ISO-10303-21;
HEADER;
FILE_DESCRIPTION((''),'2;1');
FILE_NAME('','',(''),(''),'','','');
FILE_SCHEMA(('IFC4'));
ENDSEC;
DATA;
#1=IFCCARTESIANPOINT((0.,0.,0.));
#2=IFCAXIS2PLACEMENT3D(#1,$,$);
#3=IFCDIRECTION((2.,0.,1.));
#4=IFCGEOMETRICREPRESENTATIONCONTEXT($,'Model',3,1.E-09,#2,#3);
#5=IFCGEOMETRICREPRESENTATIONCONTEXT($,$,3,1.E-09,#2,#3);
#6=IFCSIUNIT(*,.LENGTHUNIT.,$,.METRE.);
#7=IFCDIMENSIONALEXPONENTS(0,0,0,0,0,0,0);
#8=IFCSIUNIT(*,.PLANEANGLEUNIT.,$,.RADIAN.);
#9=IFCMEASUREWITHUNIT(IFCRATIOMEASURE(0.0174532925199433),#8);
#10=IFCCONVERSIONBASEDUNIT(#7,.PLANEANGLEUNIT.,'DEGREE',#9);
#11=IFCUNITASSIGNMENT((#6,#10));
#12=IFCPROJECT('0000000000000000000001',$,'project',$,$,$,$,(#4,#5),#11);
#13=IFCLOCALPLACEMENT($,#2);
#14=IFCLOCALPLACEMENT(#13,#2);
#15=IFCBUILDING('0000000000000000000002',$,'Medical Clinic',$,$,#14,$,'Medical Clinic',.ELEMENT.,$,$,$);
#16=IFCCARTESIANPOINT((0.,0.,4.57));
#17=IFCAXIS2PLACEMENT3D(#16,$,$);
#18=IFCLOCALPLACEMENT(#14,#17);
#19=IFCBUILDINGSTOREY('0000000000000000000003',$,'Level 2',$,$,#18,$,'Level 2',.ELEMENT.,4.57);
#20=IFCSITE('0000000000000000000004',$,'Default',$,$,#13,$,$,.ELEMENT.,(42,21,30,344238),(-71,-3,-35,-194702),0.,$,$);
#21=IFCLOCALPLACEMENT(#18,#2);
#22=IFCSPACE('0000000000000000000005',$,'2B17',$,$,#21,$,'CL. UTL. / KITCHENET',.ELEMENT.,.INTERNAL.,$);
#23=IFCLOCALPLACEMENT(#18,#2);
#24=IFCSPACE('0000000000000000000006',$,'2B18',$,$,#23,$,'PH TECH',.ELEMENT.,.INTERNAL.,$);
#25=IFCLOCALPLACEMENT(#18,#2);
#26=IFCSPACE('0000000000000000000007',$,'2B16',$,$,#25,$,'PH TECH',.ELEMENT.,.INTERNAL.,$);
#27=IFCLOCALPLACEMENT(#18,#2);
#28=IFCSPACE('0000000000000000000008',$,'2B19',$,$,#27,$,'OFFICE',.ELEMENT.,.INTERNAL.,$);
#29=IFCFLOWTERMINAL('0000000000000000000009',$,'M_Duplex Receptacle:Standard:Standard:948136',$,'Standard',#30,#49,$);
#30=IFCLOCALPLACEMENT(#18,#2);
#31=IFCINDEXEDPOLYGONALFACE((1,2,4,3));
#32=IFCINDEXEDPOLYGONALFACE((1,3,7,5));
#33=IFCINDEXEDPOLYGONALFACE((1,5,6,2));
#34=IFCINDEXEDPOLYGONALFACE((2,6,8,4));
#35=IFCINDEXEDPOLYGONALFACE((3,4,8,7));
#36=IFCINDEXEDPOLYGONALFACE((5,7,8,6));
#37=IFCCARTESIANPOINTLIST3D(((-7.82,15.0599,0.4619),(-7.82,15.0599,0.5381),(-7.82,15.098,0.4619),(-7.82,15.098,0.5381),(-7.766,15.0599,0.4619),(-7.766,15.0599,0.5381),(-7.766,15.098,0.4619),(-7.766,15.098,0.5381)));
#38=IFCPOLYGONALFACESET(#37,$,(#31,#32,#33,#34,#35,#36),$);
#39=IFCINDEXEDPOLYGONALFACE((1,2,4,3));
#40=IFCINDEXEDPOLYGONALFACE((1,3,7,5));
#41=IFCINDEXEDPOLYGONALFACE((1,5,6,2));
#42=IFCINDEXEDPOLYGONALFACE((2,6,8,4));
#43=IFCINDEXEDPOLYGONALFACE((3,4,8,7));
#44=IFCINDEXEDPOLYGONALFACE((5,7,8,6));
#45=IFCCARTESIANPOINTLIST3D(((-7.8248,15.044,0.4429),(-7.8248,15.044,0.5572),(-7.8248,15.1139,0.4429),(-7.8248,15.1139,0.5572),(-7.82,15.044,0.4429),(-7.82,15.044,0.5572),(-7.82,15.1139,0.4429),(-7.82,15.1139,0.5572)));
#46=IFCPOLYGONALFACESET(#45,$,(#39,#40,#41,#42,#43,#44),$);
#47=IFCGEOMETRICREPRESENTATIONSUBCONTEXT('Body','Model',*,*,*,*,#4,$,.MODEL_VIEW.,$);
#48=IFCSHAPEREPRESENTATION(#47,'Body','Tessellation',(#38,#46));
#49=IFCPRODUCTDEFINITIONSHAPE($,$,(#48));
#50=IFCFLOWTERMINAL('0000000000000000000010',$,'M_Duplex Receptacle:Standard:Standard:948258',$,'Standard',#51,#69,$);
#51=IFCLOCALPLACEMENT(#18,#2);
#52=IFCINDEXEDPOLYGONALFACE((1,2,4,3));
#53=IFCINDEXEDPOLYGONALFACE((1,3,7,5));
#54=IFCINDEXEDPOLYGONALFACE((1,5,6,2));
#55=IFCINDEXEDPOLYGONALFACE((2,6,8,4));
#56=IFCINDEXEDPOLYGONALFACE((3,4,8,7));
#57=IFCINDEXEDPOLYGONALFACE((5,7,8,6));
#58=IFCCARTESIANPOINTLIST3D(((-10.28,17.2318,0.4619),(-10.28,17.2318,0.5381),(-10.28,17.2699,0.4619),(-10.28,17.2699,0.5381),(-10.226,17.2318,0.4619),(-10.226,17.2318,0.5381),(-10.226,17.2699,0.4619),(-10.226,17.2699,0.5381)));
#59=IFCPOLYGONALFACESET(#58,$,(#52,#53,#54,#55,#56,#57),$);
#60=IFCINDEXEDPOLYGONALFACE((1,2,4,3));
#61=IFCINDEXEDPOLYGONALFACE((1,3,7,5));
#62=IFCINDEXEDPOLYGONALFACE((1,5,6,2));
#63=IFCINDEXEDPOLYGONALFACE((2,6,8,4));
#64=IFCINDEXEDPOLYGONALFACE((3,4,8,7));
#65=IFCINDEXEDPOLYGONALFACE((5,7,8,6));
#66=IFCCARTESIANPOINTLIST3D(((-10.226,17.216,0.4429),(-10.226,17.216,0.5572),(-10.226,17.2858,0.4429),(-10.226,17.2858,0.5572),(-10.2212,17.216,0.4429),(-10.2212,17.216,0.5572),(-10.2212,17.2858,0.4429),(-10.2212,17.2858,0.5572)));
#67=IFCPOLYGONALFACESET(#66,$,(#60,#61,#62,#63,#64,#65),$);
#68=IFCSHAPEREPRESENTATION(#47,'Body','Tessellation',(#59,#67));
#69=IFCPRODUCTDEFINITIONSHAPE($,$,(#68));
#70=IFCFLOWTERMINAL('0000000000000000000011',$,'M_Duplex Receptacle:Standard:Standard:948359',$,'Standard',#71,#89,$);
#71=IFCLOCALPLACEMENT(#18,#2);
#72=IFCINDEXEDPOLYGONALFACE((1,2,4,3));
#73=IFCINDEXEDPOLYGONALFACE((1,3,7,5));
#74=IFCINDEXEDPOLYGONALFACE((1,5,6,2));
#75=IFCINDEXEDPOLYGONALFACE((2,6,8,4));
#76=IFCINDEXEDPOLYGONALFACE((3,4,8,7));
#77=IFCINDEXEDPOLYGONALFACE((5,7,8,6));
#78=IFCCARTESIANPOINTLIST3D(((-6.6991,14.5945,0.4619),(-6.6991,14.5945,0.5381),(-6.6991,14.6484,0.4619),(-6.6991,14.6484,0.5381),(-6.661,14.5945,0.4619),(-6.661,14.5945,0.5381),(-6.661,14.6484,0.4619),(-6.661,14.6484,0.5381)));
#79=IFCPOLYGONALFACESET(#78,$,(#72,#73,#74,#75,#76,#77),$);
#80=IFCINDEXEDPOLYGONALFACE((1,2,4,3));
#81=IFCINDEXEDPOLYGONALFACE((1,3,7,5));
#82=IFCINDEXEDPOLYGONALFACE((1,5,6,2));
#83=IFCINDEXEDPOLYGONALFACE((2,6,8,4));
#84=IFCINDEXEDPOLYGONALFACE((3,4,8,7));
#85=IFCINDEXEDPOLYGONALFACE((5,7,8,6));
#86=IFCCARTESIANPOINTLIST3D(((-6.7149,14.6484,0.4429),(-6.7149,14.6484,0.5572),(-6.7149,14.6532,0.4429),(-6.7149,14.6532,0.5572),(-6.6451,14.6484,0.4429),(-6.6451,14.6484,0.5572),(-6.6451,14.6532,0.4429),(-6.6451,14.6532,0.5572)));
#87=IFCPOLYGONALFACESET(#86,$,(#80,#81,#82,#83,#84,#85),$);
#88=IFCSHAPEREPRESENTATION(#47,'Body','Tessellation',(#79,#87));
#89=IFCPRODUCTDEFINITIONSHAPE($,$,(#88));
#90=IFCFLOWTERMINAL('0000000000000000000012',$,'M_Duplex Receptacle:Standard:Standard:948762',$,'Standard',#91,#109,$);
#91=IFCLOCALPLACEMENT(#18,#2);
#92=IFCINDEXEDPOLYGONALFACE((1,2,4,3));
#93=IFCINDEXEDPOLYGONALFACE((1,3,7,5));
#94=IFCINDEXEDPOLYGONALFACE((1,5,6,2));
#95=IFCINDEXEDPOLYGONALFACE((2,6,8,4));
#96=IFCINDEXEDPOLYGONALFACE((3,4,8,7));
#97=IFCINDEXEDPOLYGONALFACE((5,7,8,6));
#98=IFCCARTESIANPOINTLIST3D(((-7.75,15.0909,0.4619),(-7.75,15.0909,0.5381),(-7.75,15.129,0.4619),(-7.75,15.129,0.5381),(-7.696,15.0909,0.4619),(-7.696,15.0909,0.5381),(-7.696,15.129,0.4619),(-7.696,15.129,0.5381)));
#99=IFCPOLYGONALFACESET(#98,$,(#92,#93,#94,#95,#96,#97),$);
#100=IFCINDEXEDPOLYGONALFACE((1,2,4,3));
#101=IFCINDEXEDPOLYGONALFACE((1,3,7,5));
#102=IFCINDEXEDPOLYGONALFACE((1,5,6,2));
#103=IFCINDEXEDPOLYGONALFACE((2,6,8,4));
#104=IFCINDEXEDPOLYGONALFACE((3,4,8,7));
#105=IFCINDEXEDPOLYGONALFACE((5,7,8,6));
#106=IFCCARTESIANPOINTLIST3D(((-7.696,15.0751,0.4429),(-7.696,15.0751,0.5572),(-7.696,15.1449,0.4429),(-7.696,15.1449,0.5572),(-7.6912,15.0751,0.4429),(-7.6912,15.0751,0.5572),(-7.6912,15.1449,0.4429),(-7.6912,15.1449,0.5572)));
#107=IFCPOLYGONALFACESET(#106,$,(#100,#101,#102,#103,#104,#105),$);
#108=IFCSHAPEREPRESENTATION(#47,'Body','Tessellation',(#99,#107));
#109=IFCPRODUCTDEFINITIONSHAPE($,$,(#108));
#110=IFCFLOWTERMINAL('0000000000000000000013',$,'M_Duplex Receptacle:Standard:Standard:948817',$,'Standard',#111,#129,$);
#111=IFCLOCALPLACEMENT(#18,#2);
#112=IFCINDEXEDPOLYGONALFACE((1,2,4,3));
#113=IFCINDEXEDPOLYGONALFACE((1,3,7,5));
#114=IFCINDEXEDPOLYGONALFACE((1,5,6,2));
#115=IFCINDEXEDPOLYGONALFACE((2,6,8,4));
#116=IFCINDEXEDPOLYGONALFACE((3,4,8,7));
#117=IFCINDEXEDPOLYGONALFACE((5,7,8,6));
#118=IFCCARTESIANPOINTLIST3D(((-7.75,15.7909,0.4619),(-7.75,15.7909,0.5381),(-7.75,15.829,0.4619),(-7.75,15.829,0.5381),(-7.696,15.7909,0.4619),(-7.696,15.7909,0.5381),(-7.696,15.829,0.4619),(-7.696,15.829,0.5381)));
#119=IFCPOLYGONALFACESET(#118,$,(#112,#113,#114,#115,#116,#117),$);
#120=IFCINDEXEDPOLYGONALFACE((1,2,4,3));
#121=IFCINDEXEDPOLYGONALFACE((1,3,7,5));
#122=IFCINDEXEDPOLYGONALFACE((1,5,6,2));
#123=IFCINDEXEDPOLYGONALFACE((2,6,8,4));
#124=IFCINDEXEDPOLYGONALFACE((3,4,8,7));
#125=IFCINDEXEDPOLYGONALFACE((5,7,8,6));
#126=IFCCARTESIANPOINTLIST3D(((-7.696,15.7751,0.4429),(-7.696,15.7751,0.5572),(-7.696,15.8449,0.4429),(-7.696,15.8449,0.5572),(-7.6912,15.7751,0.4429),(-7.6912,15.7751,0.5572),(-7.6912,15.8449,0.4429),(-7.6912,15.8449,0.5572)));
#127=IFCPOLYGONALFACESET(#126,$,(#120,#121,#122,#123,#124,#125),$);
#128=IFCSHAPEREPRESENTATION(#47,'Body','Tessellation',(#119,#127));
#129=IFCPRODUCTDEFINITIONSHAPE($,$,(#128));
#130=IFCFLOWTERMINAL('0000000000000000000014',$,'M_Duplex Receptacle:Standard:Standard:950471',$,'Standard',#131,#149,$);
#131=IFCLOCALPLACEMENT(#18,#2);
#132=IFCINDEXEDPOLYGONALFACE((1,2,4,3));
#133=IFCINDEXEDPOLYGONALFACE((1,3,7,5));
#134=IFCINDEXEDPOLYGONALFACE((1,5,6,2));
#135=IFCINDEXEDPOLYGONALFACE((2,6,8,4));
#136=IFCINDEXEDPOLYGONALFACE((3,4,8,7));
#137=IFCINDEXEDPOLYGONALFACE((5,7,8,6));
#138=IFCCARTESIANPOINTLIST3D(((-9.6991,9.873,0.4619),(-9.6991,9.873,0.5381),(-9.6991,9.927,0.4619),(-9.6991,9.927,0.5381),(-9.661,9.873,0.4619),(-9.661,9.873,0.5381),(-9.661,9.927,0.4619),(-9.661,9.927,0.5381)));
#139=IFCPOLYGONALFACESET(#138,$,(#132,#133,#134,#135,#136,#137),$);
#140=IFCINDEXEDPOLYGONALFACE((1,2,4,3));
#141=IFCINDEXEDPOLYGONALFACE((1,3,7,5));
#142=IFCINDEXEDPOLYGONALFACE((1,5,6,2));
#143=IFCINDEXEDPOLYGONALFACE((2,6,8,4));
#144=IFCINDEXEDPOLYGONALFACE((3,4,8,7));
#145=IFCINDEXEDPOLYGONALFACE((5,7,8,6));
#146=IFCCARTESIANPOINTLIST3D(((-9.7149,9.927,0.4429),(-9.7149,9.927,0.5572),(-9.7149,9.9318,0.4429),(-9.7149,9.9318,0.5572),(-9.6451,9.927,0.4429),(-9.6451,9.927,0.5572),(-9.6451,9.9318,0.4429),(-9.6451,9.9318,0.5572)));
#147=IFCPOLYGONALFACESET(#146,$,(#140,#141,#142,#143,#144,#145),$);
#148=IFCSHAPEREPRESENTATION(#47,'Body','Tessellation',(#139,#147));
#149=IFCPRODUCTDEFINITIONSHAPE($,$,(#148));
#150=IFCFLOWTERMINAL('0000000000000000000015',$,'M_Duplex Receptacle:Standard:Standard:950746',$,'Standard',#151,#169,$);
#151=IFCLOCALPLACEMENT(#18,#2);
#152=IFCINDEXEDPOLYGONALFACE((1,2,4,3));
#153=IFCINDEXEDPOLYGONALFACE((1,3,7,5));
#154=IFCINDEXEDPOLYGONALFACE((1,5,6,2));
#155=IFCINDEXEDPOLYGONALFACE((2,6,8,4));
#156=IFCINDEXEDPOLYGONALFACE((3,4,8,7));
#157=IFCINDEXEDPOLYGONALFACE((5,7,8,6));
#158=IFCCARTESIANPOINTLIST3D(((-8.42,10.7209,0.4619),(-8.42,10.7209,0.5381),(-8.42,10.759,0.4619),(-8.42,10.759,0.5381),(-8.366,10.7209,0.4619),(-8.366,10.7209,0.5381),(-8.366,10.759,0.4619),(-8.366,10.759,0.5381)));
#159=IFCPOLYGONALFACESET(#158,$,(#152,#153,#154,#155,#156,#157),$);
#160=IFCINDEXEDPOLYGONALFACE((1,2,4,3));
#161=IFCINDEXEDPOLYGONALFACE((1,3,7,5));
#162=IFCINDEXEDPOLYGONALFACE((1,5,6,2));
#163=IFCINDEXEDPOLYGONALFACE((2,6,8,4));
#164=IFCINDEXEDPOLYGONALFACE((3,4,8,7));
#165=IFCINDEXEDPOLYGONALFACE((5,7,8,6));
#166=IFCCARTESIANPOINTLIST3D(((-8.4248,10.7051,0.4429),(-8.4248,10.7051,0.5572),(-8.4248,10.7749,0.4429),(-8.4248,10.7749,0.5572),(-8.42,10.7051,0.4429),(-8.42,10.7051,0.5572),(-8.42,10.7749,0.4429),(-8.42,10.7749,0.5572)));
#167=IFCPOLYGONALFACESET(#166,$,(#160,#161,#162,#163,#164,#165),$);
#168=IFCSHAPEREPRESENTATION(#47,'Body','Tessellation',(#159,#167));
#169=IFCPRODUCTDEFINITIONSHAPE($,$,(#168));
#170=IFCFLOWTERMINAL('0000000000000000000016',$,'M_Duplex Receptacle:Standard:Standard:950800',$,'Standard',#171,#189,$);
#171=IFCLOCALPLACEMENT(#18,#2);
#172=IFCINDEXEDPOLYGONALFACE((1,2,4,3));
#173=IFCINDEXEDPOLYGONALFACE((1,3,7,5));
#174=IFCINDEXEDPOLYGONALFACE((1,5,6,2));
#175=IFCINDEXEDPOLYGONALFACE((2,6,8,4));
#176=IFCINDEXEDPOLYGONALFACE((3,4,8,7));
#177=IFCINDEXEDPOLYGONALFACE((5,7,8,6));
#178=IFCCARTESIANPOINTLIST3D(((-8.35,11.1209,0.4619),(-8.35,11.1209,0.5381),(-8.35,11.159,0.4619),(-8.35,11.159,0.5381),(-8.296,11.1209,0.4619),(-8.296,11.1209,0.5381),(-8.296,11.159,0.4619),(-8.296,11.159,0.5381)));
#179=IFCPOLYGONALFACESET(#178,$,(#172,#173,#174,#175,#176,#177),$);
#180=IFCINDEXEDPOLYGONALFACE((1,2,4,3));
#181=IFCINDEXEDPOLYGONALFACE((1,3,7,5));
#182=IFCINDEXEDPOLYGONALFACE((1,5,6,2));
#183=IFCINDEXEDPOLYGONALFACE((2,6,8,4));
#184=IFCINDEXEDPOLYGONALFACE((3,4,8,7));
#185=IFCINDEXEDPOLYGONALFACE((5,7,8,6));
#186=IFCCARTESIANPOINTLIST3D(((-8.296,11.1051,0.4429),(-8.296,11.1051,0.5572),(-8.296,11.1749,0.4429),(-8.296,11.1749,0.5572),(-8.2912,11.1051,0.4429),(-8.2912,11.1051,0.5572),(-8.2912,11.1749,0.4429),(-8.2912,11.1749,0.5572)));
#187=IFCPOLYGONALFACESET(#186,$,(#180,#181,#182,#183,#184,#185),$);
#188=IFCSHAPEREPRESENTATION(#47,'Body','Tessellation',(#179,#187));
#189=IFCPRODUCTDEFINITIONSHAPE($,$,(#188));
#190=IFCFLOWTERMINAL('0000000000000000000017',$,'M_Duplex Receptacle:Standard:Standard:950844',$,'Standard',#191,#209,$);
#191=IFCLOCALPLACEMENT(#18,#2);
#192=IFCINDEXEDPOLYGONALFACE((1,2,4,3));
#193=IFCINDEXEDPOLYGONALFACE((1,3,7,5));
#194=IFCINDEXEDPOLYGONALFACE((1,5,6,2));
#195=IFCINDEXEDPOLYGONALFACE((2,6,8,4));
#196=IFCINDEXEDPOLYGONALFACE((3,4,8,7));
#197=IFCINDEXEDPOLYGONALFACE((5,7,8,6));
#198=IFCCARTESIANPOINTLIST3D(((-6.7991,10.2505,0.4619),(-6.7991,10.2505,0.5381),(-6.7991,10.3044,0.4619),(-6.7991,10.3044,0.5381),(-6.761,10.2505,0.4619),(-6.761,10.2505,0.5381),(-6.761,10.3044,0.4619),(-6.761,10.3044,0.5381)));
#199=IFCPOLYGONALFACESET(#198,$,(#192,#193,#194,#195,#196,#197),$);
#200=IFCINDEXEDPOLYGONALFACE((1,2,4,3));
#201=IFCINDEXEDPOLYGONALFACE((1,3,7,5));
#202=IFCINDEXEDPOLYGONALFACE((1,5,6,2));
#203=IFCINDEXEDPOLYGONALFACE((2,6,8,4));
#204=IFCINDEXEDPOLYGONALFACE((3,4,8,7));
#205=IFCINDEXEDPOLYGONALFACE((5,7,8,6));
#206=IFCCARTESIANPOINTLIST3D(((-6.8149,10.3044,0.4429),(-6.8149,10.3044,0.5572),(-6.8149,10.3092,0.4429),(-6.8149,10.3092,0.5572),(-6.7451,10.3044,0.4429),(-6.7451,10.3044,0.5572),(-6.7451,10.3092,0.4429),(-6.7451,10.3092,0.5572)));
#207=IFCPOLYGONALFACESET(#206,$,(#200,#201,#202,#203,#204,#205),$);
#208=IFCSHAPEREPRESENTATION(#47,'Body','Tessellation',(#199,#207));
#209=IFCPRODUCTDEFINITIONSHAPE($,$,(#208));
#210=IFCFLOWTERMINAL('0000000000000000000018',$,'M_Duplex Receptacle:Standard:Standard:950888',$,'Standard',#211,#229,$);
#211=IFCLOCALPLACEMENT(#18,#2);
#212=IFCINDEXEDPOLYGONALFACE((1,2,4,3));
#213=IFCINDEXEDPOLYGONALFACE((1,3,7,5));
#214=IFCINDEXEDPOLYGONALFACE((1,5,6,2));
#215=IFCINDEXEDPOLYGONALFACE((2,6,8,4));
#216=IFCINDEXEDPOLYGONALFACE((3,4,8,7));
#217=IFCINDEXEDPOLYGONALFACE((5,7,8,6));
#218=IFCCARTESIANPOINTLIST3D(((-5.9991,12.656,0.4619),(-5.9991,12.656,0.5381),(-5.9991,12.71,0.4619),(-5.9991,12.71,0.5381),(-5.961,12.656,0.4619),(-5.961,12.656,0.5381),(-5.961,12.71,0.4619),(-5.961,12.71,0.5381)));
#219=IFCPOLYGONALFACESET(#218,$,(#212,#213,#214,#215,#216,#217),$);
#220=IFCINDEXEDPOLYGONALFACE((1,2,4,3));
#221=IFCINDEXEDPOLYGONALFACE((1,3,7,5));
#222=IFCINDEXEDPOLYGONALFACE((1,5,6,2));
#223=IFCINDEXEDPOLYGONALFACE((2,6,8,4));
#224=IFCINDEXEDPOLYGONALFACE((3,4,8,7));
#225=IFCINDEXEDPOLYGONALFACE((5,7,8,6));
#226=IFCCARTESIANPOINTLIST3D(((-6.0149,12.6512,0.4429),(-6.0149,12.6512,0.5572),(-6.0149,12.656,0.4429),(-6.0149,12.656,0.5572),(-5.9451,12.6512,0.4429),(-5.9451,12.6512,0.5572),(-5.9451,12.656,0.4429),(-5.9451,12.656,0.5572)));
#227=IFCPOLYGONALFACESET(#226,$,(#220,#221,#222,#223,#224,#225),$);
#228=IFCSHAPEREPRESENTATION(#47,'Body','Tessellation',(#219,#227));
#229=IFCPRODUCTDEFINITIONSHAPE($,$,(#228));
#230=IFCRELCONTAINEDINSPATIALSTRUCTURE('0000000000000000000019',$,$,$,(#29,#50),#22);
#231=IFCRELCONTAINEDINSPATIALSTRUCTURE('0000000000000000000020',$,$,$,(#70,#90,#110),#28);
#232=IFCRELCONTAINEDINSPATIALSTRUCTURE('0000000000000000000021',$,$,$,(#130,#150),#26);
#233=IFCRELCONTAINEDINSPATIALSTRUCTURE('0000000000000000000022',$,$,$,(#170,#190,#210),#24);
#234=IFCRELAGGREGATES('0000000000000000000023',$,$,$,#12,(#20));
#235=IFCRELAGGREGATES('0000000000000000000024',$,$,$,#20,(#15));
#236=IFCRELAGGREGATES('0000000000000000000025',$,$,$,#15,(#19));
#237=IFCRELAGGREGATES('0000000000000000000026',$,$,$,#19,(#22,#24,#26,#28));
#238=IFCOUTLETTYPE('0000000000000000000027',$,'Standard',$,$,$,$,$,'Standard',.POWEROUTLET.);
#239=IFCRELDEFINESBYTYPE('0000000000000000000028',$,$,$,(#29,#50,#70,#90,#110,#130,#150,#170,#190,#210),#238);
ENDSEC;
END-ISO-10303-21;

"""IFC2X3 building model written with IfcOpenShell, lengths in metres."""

from ifc_helpers import new_model, entity, si_unit, converted_unit, direction, frame, frame_2d, origin, origin_2d_with_axis, place, context, subcontext, project, spatial, rectangle, extrude, source, transform, mapped, type_object, type_shapes, element, save


model = new_model("IFC2X3")

# Units and contexts
model_context = context("Model", 3, precision=1e-09, world=origin(), true_north=direction((2.0, 0.0, 1.0)))
context_of_model = context(None, 3, precision=1e-09, world=origin(), true_north=direction((2.0, 0.0, 1.0)))
body_context = subcontext(model_context, "Body", "Model", "MODEL_VIEW")
ifc_project = project(units=[si_unit("LENGTHUNIT", "METRE"), converted_unit("PLANEANGLEUNIT", "DEGREE", entity("IfcRatioMeasure", 0.0174532925199433), si_unit("PLANEANGLEUNIT", "RADIAN"), dimensions=[0, 0, 0, 0, 0, 0, 0])], contexts=[model_context, context_of_model])

# Site, building, storey
site_placement = place(None, origin())
site = spatial("IfcSite", under=ifc_project, at=site_placement, Name="Default", CompositionType="ELEMENT", RefLatitude=(42, 21, 30, 344238), RefLongitude=(-71, -3, -35, -194702), RefElevation=0.0)
building_placement = place(site_placement, origin())
building = spatial("IfcBuilding", under=site, at=building_placement, Name="Medical Clinic", LongName="Medical Clinic", CompositionType="ELEMENT")
storey_placement = place(building_placement, frame((0.0, 0.0, 4.57)))
storey = spatial("IfcBuildingStorey", under=building, at=storey_placement, Name="Level 2", LongName="Level 2", CompositionType="ELEMENT", Elevation=4.57)

# Shared definitions
space_1_placement = place(storey_placement, origin())
space_1 = spatial("IfcSpace", under=storey, at=space_1_placement, Name="2B17", LongName="CL. UTL. / KITCHENET", CompositionType="ELEMENT", InteriorOrExteriorSpace="INTERNAL")

# Shared definitions
space_2_placement = place(storey_placement, origin())
space_2 = spatial("IfcSpace", under=storey, at=space_2_placement, Name="2B18", LongName="PH TECH", CompositionType="ELEMENT", InteriorOrExteriorSpace="INTERNAL")

# Shared definitions
space_3_placement = place(storey_placement, origin())
space_3 = spatial("IfcSpace", under=storey, at=space_3_placement, Name="2B16", LongName="PH TECH", CompositionType="ELEMENT", InteriorOrExteriorSpace="INTERNAL")

# Shared definitions
outlet_type = type_object("IfcOutletType", Name="Standard", ElementType="Standard", PredefinedType="POWEROUTLET")
shared_shape_1 = source(origin(), body_context, "Body", "SweptSolid", [
    extrude(rectangle(XDim=0.0381, YDim=0.0762, at=origin_2d_with_axis()), frame((0.0, 0.0, -0.054), z_axis=(0.0, 0.0, 1.0), x_axis=(-1.0, 0.0, 0.0)), (0.0, 0.0, 1.0), 0.054),
    extrude(rectangle(XDim=0.0698, YDim=0.1143, at=frame_2d((0.0, 0.0), x_axis=(1.0, 0.0))), frame((0.0, 0.0, 0.0), z_axis=(0.0, 0.0, 1.0), x_axis=(-1.0, 0.0, 0.0)), (0.0, 0.0, 1.0), 0.0048),
])
type_shapes(outlet_type, [shared_shape_1])

# Shared definitions
space_4_placement = place(storey_placement, origin())
space_4 = spatial("IfcSpace", under=storey, at=space_4_placement, Name="2B19", LongName="OFFICE", CompositionType="ELEMENT", InteriorOrExteriorSpace="INTERNAL")

# Flow terminals
for number, where, z_axis, x_axis, name in (
    (1, (-7.82, 15.079, 0.5), (-1.0, 0.0, 0.0), (0.0, -1.0, 0.0), "M_Duplex Receptacle:Standard:Standard:948136"),
    (2, (-10.226, 17.2509, 0.5), (1.0, 0.0, 0.0), (0.0, 1.0, 0.0), "M_Duplex Receptacle:Standard:Standard:948258"),
):
    element("IfcFlowTerminal", number, at=place(space_1_placement, frame(where, z_axis=z_axis, x_axis=x_axis)), inside=space_1, type_object=outlet_type, Name=name, ObjectType="Standard", context=body_context, shape_type="MappedRepresentation", body=[
        mapped(shared_shape_1, transform((0.0, 0.0, 0.0), scale=1.0)),
    ])
for number, where, z_axis, x_axis, name in (
    (3, (-6.68, 14.6484, 0.5), (0.0, 1.0, 0.0), (-1.0, 0.0, 0.0), "M_Duplex Receptacle:Standard:Standard:948359"),
    (4, (-7.696, 15.11, 0.5), (1.0, 0.0, 0.0), (0.0, 1.0, 0.0), "M_Duplex Receptacle:Standard:Standard:948762"),
    (5, (-7.696, 15.81, 0.5), (1.0, 0.0, 0.0), (0.0, 1.0, 0.0), "M_Duplex Receptacle:Standard:Standard:948817"),
):
    element("IfcFlowTerminal", number, at=place(space_4_placement, frame(where, z_axis=z_axis, x_axis=x_axis)), inside=space_4, type_object=outlet_type, Name=name, ObjectType="Standard", context=body_context, shape_type="MappedRepresentation", body=[
        mapped(shared_shape_1, transform((0.0, 0.0, 0.0), scale=1.0)),
    ])
for number, where, z_axis, x_axis, name in (
    (6, (-9.68, 9.927, 0.5), (0.0, 1.0, 0.0), (-1.0, 0.0, 0.0), "M_Duplex Receptacle:Standard:Standard:950471"),
    (7, (-8.42, 10.74, 0.5), (-1.0, 0.0, 0.0), (0.0, -1.0, 0.0), "M_Duplex Receptacle:Standard:Standard:950746"),
):
    element("IfcFlowTerminal", number, at=place(space_3_placement, frame(where, z_axis=z_axis, x_axis=x_axis)), inside=space_3, type_object=outlet_type, Name=name, ObjectType="Standard", context=body_context, shape_type="MappedRepresentation", body=[
        mapped(shared_shape_1, transform((0.0, 0.0, 0.0), scale=1.0)),
    ])
for number, where, z_axis, x_axis, name in (
    (8, (-8.296, 11.14, 0.5), (1.0, 0.0, 0.0), (0.0, 1.0, 0.0), "M_Duplex Receptacle:Standard:Standard:950800"),
    (9, (-6.78, 10.3044, 0.5), (0.0, 1.0, 0.0), (-1.0, 0.0, 0.0), "M_Duplex Receptacle:Standard:Standard:950844"),
    (10, (-5.98, 12.656, 0.5), (0.0, -1.0, 0.0), (1.0, 0.0, 0.0), "M_Duplex Receptacle:Standard:Standard:950888"),
):
    element("IfcFlowTerminal", number, at=place(space_2_placement, frame(where, z_axis=z_axis, x_axis=x_axis)), inside=space_2, type_object=outlet_type, Name=name, ObjectType="Standard", context=body_context, shape_type="MappedRepresentation", body=[
        mapped(shared_shape_1, transform((0.0, 0.0, 0.0), scale=1.0)),
    ])

save(model, "model.ifc")
